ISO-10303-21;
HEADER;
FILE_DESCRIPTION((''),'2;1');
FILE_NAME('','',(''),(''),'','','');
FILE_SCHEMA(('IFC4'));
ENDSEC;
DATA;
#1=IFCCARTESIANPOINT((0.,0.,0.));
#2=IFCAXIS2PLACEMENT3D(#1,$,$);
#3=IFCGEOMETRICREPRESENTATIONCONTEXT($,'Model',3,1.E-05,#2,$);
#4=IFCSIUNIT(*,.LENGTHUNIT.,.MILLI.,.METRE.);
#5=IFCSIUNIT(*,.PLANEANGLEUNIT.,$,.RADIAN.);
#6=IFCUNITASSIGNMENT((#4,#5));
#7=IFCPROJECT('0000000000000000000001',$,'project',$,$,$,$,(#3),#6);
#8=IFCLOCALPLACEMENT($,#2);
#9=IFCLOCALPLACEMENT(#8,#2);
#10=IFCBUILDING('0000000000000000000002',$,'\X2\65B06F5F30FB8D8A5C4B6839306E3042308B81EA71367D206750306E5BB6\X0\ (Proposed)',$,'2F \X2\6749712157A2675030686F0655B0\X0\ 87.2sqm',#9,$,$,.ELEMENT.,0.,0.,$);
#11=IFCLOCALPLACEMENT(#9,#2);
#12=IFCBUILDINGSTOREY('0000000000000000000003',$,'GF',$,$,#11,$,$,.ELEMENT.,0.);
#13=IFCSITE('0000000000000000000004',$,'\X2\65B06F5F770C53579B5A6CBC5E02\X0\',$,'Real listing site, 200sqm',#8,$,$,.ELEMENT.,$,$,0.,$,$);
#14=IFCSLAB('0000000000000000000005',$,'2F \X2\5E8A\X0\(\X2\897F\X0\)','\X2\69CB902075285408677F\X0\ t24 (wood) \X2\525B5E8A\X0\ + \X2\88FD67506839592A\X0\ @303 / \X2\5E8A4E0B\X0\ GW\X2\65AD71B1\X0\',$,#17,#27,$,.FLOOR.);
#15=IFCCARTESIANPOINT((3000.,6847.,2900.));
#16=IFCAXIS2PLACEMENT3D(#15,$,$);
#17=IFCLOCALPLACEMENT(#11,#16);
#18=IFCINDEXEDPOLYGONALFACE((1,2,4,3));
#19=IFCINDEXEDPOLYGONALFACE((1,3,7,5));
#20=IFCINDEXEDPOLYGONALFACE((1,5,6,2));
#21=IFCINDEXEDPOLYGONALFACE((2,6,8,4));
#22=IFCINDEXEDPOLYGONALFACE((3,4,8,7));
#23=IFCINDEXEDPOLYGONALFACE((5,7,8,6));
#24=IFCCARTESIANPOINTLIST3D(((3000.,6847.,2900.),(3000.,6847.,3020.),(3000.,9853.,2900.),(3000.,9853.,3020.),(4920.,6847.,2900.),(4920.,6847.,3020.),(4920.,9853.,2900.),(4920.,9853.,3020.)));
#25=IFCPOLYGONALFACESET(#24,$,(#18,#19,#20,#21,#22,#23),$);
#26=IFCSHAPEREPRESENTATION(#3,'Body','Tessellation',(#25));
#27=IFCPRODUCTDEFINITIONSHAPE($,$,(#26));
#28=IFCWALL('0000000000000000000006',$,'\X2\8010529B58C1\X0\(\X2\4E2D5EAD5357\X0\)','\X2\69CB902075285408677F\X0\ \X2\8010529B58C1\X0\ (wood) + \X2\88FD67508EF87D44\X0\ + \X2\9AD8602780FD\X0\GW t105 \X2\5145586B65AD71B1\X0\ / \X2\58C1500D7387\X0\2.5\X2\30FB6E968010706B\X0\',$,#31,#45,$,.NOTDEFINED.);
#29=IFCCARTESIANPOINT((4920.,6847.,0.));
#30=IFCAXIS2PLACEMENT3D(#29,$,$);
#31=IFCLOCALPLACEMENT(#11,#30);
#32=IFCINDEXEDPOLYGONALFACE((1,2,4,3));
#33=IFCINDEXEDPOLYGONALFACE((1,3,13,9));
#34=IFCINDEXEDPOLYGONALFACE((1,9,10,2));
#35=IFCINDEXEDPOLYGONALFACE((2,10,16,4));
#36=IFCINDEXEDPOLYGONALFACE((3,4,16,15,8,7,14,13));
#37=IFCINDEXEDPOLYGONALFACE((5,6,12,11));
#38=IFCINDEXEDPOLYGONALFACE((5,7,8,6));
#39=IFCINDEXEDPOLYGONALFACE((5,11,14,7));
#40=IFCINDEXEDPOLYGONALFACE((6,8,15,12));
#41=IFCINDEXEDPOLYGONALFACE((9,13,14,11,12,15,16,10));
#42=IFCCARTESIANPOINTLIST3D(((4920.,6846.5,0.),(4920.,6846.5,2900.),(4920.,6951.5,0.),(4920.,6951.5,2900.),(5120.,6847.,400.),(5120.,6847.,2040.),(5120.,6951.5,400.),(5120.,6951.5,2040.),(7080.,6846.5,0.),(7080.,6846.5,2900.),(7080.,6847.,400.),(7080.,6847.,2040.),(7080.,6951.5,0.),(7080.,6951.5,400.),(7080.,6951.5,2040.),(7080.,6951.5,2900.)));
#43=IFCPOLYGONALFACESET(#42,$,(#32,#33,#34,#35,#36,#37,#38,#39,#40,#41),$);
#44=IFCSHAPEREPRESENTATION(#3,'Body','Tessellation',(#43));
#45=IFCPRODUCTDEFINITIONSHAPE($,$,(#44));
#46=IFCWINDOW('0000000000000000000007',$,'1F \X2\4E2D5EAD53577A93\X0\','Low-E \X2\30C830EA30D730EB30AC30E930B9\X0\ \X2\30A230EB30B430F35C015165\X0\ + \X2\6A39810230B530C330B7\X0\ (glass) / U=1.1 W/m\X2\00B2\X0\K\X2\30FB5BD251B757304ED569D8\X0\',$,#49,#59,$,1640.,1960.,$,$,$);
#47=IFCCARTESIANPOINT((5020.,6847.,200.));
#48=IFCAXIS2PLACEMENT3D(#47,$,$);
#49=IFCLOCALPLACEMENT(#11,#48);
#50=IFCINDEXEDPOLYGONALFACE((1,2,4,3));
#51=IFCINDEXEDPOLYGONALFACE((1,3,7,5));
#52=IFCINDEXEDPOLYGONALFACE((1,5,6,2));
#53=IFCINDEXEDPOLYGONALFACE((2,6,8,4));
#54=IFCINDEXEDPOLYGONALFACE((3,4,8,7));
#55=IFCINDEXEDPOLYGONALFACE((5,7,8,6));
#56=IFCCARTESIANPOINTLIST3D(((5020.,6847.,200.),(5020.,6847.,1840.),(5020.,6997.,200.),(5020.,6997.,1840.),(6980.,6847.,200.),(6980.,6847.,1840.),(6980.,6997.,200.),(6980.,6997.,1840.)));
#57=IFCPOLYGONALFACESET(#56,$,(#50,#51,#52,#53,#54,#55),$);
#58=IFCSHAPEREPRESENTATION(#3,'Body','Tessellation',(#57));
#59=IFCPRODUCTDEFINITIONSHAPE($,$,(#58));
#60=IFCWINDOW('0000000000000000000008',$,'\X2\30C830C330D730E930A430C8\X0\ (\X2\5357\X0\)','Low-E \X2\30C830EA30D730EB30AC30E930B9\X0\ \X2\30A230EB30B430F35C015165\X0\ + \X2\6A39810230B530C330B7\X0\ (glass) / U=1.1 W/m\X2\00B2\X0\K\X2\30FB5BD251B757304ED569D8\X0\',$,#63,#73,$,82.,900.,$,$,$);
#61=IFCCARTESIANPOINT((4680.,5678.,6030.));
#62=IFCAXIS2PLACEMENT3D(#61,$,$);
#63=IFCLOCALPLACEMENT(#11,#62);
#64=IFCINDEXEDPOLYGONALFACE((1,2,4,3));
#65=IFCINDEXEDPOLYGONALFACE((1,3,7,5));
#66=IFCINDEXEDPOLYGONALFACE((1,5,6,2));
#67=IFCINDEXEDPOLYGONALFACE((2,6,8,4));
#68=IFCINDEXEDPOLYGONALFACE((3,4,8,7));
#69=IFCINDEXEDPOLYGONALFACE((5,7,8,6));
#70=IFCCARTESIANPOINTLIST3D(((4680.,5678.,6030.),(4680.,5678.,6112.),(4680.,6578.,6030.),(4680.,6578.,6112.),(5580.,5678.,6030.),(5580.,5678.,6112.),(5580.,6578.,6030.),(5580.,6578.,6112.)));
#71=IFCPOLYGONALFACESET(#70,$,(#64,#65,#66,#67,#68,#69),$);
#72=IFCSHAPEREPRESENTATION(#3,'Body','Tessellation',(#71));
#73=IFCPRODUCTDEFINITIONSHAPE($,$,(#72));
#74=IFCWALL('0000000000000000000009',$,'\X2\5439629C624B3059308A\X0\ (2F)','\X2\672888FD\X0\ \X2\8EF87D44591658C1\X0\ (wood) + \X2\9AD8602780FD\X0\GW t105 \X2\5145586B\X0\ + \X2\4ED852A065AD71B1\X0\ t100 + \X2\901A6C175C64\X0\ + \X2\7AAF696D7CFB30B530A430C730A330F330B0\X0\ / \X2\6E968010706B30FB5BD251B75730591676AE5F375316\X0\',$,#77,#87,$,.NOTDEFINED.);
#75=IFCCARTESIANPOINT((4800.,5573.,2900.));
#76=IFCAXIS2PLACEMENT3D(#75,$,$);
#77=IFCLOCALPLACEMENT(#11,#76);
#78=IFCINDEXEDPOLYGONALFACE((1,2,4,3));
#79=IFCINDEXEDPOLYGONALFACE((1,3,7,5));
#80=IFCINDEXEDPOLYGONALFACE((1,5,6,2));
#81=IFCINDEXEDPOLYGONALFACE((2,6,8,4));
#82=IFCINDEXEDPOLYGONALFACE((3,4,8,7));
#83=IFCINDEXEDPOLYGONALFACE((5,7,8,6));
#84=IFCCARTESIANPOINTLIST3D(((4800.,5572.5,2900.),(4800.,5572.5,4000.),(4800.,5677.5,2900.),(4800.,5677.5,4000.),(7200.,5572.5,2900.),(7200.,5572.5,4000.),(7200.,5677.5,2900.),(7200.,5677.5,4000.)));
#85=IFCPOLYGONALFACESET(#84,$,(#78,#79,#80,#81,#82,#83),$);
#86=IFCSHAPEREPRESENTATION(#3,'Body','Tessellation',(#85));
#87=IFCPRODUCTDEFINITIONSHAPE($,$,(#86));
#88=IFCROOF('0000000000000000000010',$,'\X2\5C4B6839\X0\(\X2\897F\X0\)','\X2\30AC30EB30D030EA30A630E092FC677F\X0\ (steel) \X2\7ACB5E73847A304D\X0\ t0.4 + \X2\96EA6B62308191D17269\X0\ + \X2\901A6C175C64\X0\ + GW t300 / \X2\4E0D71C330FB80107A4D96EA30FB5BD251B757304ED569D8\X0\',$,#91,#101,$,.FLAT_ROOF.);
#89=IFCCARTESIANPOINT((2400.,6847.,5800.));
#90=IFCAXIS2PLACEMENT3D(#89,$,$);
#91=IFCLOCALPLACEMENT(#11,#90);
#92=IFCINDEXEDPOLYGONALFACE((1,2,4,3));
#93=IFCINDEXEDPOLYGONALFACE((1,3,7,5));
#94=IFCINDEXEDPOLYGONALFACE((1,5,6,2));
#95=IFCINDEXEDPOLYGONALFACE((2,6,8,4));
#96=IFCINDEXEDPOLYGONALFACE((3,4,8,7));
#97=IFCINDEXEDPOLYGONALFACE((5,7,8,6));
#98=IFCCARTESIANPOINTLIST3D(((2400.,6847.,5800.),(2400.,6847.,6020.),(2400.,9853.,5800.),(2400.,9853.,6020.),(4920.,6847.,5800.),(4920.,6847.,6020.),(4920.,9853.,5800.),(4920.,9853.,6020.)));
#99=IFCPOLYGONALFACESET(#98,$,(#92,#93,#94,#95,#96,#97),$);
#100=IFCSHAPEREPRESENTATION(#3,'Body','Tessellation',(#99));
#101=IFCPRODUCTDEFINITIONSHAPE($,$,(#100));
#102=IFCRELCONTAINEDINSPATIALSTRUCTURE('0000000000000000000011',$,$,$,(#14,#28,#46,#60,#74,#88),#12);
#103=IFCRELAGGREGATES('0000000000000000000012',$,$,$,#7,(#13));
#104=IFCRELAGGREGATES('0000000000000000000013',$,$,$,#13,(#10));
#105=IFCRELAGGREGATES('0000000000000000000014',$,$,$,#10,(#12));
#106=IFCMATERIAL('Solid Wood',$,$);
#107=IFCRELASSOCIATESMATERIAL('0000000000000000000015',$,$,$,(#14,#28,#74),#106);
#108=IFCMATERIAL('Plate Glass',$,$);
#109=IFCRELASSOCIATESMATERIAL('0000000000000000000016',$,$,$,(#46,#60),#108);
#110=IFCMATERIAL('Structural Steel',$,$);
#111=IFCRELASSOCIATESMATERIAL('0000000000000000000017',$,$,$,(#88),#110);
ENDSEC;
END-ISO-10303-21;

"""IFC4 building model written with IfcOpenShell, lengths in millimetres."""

from ifc_helpers import new_model, si_unit, frame, frame_2d, origin, place, context, project, spatial, rectangle, extrude, material, element, fill, save


model = new_model("IFC4")

# Units and contexts
model_context = context("Model", 3, precision=1e-05, world=origin())
ifc_project = project(units=[si_unit("LENGTHUNIT", "METRE", prefix="MILLI"), si_unit("PLANEANGLEUNIT", "RADIAN")], contexts=[model_context])

# Site, building, storey
site_placement = place(None, origin())
site = spatial("IfcSite", under=ifc_project, at=site_placement, Name="新潟県南魚沼市", ObjectType="Real listing site, 200sqm", CompositionType="ELEMENT", RefElevation=0.0)
building_placement = place(site_placement, origin())
building = spatial("IfcBuilding", under=site, at=building_placement, Name="新潟・越屋根のある自然素材の家 (Proposed)", ObjectType="2F 杉無垢材と漆喰 87.2sqm", CompositionType="ELEMENT", ElevationOfRefHeight=0.0, ElevationOfTerrain=0.0)
storey_placement = place(building_placement, origin())
storey = spatial("IfcBuildingStorey", under=building, at=storey_placement, Name="GF", CompositionType="ELEMENT", Elevation=0.0)

# Shared definitions
ifc_material_1 = material(Name="Solid Wood")

# Slab
slab_1_placement = place(storey_placement, frame((3000.0, 6847.0, 2900.0)))
element("IfcSlab", 1, at=slab_1_placement, inside=storey, material=ifc_material_1, Name="2F 床(西)", Description="構造用合板 t24 (wood) 剛床 + 製材根太 @303 / 床下 GW断熱", PredefinedType="FLOOR", context=model_context, shape_type="SweptSolid", body=[
    extrude(rectangle(XDim=1920.0, YDim=3006.0, at=frame_2d((960.0, 1503.0))), frame((3000.0, 6847.0, 2900.0)), (0.0, 0.0, 1.0), 120.0),
])

# Wall, opening, window
wall_1_placement = place(storey_placement, frame((4920.0, 6847.0, 0.0)))
wall_1 = element("IfcWall", 2, at=wall_1_placement, inside=storey, material=ifc_material_1, Name="耐力壁(中庭南)", Description="構造用合板 耐力壁 (wood) + 製材軸組 + 高性能GW t105 充填断熱 / 壁倍率2.5・準耐火", PredefinedType="NOTDEFINED", context=model_context, shape_type="SweptSolid", body=[
    extrude(rectangle(XDim=2160.0, YDim=105.0, at=frame_2d((1080.0, 52.0))), frame((4920.0, 6847.0, 0.0)), (0.0, 0.0, 1.0), 2900.0),
])
opening_placement = place(storey_placement, frame((5020.0, 6847.0, 200.0)))
opening = element("IfcOpeningElement", 3, at=opening_placement, cuts=wall_1, PredefinedType="NOTDEFINED", context=model_context, shape_type="SweptSolid", body=[
    extrude(rectangle(XDim=1960.0, YDim=150.0, at=frame_2d((980.0, 75.0))), frame((5020.0, 6847.0, 200.0)), (0.0, 0.0, 1.0), 1640.0),
])
ifc_material_2 = material(Name="Plate Glass")
window_1_placement = place(storey_placement, frame((5020.0, 6847.0, 200.0)))
window_1 = element("IfcWindow", 4, at=window_1_placement, inside=storey, material=ifc_material_2, Name="1F 中庭南窓", Description="Low-E トリプルガラス アルゴン封入 + 樹脂サッシ (glass) / U=1.1 W/m²K・寒冷地仕様", OverallHeight=1640.0, OverallWidth=1960.0, context=model_context, shape_type="SweptSolid", body=[
    extrude(rectangle(XDim=1960.0, YDim=150.0, at=frame_2d((980.0, 75.0))), frame((5020.0, 6847.0, 200.0)), (0.0, 0.0, 1.0), 1640.0),
])
fill(opening, window_1)

# Window
window_2_placement = place(storey_placement, frame((4680.0, 5678.0, 6030.0)))
element("IfcWindow", 5, at=window_2_placement, inside=storey, material=ifc_material_2, Name="トップライト (南)", Description="Low-E トリプルガラス アルゴン封入 + 樹脂サッシ (glass) / U=1.1 W/m²K・寒冷地仕様", OverallHeight=82.0, OverallWidth=900.0, context=model_context, shape_type="SweptSolid", body=[
    extrude(rectangle(XDim=900.0, YDim=900.0, at=frame_2d((450.0, 450.0))), frame((4680.0, 5678.0, 6030.0)), (0.0, 0.0, 1.0), 82.0),
])

# Wall
wall_2_placement = place(storey_placement, frame((4800.0, 5573.0, 2900.0)))
element("IfcWall", 6, at=wall_2_placement, inside=storey, material=ifc_material_1, Name="吹抜手すり (2F)", Description="木製 軸組外壁 (wood) + 高性能GW t105 充填 + 付加断熱 t100 + 通気層 + 窯業系サイディング / 準耐火・寒冷地外皮強化", PredefinedType="NOTDEFINED", context=model_context, shape_type="SweptSolid", body=[
    extrude(rectangle(XDim=2400.0, YDim=105.0, at=frame_2d((1200.0, 52.0))), frame((4800.0, 5573.0, 2900.0)), (0.0, 0.0, 1.0), 1100.0),
])

# Roof
ifc_material_3 = material(Name="Structural Steel")
for number, where, name in (
    (7, (2400.0, 6847.0, 5800.0), "屋根(西)"),
):
    element("IfcRoof", number, at=place(storey_placement, frame(where)), inside=storey, material=ifc_material_3, Name=name, Description="ガルバリウム鋼板 (steel) 立平葺き t0.4 + 雪止め金物 + 通気層 + GW t300 / 不燃・耐積雪・寒冷地仕様", PredefinedType="FLAT_ROOF", context=model_context, shape_type="SweptSolid", body=[
        extrude(rectangle(XDim=2520.0, YDim=3006.0, at=frame_2d((1260.0, 1503.0))), frame((2400.0, 6847.0, 5800.0)), (0.0, 0.0, 1.0), 220.0),
    ])

save(model, "model.ifc")
